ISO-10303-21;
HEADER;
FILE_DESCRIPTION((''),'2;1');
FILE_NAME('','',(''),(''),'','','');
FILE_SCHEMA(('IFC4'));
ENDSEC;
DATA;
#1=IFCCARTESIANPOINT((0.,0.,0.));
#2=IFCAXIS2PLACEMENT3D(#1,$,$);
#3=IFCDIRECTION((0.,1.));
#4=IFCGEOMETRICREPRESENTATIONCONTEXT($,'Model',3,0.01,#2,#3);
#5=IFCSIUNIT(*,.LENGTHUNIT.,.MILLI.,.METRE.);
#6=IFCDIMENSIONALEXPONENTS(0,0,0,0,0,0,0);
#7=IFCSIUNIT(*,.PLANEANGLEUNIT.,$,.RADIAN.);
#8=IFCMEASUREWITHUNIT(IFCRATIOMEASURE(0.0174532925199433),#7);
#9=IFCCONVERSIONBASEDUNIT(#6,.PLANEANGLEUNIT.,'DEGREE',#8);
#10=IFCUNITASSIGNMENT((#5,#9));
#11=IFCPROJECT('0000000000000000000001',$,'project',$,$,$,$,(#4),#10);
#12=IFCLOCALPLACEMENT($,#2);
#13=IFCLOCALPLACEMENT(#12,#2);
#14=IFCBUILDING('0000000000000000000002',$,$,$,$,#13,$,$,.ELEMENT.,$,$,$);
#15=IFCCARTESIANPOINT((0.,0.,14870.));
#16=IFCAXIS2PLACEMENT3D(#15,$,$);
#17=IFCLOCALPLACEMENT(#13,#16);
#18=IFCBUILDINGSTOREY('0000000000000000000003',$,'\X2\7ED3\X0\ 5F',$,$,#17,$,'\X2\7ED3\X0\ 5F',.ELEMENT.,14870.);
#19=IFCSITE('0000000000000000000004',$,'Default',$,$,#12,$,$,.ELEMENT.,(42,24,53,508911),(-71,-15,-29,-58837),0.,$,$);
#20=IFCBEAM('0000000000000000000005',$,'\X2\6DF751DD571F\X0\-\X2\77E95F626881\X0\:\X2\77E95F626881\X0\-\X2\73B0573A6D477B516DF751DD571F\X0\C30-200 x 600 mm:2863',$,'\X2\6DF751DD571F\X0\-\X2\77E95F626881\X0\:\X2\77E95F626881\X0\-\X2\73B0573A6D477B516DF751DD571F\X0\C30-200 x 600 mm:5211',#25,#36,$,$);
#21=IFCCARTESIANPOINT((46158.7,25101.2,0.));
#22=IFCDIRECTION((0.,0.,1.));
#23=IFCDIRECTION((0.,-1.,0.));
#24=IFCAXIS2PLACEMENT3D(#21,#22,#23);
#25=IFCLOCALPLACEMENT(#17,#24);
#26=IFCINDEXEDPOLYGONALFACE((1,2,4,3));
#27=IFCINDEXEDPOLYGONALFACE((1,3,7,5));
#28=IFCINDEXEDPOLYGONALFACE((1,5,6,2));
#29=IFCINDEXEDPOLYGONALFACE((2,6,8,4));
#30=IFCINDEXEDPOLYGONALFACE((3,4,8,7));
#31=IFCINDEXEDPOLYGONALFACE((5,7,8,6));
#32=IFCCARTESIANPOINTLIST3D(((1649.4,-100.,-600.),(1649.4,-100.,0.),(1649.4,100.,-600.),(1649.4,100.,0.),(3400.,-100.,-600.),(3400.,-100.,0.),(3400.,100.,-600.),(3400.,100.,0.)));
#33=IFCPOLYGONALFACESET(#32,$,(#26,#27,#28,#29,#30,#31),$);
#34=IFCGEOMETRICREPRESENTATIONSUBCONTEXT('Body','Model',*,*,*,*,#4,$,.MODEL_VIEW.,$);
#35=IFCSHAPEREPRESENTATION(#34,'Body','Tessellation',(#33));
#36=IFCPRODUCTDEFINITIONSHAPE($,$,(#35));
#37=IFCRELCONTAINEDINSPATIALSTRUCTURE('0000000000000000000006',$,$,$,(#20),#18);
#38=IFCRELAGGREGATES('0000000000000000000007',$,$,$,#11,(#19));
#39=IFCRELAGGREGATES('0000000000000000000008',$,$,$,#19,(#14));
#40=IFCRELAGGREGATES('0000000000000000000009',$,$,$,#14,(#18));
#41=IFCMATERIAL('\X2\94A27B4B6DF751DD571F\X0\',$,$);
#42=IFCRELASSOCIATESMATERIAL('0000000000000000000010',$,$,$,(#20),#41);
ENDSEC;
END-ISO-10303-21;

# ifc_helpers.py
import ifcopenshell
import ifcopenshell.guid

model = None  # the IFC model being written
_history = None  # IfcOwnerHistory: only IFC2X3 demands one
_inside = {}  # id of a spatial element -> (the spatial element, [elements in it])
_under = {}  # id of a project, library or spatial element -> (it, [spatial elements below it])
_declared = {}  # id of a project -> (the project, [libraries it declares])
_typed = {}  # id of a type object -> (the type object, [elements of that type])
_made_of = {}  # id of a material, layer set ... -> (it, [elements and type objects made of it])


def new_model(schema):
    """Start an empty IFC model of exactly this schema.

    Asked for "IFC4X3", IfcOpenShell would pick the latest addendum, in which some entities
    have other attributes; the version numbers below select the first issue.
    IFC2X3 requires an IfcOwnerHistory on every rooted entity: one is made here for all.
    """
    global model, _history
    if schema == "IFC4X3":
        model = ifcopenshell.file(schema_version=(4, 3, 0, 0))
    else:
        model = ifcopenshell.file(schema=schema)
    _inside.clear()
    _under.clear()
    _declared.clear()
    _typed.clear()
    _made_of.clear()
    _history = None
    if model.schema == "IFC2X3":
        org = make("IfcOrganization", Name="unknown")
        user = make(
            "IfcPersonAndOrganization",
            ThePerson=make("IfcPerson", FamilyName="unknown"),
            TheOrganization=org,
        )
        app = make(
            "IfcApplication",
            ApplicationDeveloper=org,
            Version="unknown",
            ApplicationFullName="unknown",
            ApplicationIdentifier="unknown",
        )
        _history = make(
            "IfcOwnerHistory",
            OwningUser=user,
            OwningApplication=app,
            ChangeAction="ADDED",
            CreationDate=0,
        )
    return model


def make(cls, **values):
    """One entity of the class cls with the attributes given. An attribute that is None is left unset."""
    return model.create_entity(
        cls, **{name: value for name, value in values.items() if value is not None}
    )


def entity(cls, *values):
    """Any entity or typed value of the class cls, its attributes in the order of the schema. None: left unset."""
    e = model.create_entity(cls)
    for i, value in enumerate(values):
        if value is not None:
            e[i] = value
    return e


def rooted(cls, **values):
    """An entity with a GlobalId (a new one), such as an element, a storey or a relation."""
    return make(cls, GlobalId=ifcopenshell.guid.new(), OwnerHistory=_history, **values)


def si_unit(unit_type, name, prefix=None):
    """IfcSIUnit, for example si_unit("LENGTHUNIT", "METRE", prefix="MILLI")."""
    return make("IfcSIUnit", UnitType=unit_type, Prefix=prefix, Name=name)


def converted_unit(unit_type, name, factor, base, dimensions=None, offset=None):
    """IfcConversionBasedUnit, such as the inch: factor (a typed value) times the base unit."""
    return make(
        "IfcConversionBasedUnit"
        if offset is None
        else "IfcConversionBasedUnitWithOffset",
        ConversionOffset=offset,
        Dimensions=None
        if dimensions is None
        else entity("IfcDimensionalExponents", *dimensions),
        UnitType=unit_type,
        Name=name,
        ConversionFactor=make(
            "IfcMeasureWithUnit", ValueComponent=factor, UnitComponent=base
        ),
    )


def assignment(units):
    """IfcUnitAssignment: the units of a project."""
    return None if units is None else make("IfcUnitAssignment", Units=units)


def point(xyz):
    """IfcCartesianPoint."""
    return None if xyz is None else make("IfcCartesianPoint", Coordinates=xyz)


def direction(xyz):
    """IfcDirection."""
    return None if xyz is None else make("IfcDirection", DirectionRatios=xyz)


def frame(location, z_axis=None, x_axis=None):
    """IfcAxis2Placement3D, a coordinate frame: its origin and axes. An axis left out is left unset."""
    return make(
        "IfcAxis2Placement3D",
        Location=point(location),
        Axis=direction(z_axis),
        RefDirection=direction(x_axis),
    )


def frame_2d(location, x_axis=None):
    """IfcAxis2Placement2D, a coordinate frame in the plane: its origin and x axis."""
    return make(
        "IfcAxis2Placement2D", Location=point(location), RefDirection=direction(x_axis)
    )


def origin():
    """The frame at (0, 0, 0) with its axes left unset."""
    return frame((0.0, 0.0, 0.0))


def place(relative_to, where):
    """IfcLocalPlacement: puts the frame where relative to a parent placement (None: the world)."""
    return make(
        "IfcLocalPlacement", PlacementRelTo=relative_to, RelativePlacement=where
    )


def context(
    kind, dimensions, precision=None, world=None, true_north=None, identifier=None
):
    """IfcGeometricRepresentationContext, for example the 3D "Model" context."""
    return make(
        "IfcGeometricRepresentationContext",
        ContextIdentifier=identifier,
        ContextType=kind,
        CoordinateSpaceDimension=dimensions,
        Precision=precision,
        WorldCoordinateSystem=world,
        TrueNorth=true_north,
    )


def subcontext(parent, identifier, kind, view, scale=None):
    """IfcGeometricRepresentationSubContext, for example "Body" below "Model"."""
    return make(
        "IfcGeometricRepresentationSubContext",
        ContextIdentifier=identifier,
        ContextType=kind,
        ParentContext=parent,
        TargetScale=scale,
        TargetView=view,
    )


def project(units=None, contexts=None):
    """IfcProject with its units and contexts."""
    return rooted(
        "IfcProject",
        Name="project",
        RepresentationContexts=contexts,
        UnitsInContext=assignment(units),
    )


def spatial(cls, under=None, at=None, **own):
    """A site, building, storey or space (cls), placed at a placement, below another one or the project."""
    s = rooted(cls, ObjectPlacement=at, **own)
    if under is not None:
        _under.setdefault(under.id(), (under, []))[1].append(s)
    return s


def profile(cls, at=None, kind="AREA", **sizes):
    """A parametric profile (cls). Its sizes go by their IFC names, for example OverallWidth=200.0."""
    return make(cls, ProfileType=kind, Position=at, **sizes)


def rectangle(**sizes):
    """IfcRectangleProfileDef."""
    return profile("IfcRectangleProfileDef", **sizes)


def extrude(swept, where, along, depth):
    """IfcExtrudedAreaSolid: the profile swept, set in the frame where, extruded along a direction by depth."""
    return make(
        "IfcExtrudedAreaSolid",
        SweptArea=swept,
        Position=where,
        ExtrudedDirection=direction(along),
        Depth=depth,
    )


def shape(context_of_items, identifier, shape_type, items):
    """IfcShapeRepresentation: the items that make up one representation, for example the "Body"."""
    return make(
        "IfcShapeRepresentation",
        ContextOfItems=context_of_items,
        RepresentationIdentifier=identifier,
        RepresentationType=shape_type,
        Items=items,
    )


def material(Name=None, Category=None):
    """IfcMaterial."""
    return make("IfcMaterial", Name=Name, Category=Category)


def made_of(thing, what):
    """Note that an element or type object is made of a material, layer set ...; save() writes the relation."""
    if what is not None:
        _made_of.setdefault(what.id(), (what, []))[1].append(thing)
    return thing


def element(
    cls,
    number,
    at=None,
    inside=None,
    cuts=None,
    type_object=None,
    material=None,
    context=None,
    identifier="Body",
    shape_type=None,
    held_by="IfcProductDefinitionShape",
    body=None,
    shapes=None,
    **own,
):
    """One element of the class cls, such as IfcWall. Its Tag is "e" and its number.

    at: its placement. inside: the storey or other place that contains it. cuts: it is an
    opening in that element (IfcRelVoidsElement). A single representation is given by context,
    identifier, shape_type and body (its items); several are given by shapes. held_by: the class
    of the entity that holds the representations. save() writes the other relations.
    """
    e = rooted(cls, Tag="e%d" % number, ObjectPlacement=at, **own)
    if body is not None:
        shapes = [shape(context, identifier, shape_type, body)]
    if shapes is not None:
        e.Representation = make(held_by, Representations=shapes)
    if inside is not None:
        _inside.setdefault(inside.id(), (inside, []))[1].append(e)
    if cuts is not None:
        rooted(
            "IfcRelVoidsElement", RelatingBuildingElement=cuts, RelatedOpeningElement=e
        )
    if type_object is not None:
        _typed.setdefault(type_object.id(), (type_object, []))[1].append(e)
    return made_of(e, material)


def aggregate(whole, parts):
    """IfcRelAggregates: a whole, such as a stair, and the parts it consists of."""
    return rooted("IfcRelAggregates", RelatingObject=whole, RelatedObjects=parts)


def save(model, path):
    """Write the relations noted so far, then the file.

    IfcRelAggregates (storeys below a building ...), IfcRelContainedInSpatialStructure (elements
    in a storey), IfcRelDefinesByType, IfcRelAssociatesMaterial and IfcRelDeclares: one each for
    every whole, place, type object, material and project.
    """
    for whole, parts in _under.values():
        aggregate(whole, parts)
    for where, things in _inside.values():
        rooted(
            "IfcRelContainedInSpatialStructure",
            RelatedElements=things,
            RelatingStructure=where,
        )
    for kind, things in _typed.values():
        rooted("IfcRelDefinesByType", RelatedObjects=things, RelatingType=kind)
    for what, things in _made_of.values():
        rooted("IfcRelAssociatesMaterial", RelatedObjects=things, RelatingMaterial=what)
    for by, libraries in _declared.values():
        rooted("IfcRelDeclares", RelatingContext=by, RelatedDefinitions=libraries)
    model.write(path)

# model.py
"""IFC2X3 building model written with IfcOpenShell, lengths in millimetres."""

from ifc_helpers import new_model, entity, si_unit, converted_unit, direction, frame, frame_2d, origin, place, context, subcontext, project, spatial, rectangle, extrude, material, element, save


model = new_model("IFC2X3")

# Units and contexts
model_context = context("Model", 3, precision=0.01, world=origin(), true_north=direction((0.0, 1.0)))
body_context = subcontext(model_context, "Body", "Model", "MODEL_VIEW")
ifc_project = project(units=[si_unit("LENGTHUNIT", "METRE", prefix="MILLI"), converted_unit("PLANEANGLEUNIT", "DEGREE", entity("IfcRatioMeasure", 0.0174532925199433), si_unit("PLANEANGLEUNIT", "RADIAN"), dimensions=[0, 0, 0, 0, 0, 0, 0])], contexts=[model_context])

# Site, building, storey
site_placement = place(None, origin())
site = spatial("IfcSite", under=ifc_project, at=site_placement, Name="Default", CompositionType="ELEMENT", RefLatitude=(42, 24, 53, 508911), RefLongitude=(-71, -15, -29, -58837), RefElevation=0.0)
building_placement = place(site_placement, origin())
building = spatial("IfcBuilding", under=site, at=building_placement, CompositionType="ELEMENT")
storey_placement = place(building_placement, frame((0.0, 0.0, 14870.0)))
storey = spatial("IfcBuildingStorey", under=building, at=storey_placement, Name="结 5F", LongName="结 5F", CompositionType="ELEMENT", Elevation=14870.0)

# Beam
ifc_material = material(Name="钢筋混凝土")
beam_1_placement = place(storey_placement, frame((46158.7, 25101.2, 0.0), z_axis=(0.0, 0.0, 1.0), x_axis=(0.0, -1.0, 0.0)))
element("IfcBeam", 1, at=beam_1_placement, inside=storey, material=ifc_material, Name="混凝土-矩形梁:矩形梁-现场浇筑混凝土C30-200 x 600 mm:2863", ObjectType="混凝土-矩形梁:矩形梁-现场浇筑混凝土C30-200 x 600 mm:5211", context=body_context, shape_type="SweptSolid", body=[
    extrude(rectangle(XDim=600.0, YDim=200.0, at=frame_2d((0.0, 0.0), x_axis=(1.0, 0.0))), frame((1649.4, 0.0, -300.0), z_axis=(1.0, 0.0, 0.0), x_axis=(0.0, 0.0, -1.0)), (0.0, 0.0, 1.0), 1750.6),
])

save(model, "model.ifc")
